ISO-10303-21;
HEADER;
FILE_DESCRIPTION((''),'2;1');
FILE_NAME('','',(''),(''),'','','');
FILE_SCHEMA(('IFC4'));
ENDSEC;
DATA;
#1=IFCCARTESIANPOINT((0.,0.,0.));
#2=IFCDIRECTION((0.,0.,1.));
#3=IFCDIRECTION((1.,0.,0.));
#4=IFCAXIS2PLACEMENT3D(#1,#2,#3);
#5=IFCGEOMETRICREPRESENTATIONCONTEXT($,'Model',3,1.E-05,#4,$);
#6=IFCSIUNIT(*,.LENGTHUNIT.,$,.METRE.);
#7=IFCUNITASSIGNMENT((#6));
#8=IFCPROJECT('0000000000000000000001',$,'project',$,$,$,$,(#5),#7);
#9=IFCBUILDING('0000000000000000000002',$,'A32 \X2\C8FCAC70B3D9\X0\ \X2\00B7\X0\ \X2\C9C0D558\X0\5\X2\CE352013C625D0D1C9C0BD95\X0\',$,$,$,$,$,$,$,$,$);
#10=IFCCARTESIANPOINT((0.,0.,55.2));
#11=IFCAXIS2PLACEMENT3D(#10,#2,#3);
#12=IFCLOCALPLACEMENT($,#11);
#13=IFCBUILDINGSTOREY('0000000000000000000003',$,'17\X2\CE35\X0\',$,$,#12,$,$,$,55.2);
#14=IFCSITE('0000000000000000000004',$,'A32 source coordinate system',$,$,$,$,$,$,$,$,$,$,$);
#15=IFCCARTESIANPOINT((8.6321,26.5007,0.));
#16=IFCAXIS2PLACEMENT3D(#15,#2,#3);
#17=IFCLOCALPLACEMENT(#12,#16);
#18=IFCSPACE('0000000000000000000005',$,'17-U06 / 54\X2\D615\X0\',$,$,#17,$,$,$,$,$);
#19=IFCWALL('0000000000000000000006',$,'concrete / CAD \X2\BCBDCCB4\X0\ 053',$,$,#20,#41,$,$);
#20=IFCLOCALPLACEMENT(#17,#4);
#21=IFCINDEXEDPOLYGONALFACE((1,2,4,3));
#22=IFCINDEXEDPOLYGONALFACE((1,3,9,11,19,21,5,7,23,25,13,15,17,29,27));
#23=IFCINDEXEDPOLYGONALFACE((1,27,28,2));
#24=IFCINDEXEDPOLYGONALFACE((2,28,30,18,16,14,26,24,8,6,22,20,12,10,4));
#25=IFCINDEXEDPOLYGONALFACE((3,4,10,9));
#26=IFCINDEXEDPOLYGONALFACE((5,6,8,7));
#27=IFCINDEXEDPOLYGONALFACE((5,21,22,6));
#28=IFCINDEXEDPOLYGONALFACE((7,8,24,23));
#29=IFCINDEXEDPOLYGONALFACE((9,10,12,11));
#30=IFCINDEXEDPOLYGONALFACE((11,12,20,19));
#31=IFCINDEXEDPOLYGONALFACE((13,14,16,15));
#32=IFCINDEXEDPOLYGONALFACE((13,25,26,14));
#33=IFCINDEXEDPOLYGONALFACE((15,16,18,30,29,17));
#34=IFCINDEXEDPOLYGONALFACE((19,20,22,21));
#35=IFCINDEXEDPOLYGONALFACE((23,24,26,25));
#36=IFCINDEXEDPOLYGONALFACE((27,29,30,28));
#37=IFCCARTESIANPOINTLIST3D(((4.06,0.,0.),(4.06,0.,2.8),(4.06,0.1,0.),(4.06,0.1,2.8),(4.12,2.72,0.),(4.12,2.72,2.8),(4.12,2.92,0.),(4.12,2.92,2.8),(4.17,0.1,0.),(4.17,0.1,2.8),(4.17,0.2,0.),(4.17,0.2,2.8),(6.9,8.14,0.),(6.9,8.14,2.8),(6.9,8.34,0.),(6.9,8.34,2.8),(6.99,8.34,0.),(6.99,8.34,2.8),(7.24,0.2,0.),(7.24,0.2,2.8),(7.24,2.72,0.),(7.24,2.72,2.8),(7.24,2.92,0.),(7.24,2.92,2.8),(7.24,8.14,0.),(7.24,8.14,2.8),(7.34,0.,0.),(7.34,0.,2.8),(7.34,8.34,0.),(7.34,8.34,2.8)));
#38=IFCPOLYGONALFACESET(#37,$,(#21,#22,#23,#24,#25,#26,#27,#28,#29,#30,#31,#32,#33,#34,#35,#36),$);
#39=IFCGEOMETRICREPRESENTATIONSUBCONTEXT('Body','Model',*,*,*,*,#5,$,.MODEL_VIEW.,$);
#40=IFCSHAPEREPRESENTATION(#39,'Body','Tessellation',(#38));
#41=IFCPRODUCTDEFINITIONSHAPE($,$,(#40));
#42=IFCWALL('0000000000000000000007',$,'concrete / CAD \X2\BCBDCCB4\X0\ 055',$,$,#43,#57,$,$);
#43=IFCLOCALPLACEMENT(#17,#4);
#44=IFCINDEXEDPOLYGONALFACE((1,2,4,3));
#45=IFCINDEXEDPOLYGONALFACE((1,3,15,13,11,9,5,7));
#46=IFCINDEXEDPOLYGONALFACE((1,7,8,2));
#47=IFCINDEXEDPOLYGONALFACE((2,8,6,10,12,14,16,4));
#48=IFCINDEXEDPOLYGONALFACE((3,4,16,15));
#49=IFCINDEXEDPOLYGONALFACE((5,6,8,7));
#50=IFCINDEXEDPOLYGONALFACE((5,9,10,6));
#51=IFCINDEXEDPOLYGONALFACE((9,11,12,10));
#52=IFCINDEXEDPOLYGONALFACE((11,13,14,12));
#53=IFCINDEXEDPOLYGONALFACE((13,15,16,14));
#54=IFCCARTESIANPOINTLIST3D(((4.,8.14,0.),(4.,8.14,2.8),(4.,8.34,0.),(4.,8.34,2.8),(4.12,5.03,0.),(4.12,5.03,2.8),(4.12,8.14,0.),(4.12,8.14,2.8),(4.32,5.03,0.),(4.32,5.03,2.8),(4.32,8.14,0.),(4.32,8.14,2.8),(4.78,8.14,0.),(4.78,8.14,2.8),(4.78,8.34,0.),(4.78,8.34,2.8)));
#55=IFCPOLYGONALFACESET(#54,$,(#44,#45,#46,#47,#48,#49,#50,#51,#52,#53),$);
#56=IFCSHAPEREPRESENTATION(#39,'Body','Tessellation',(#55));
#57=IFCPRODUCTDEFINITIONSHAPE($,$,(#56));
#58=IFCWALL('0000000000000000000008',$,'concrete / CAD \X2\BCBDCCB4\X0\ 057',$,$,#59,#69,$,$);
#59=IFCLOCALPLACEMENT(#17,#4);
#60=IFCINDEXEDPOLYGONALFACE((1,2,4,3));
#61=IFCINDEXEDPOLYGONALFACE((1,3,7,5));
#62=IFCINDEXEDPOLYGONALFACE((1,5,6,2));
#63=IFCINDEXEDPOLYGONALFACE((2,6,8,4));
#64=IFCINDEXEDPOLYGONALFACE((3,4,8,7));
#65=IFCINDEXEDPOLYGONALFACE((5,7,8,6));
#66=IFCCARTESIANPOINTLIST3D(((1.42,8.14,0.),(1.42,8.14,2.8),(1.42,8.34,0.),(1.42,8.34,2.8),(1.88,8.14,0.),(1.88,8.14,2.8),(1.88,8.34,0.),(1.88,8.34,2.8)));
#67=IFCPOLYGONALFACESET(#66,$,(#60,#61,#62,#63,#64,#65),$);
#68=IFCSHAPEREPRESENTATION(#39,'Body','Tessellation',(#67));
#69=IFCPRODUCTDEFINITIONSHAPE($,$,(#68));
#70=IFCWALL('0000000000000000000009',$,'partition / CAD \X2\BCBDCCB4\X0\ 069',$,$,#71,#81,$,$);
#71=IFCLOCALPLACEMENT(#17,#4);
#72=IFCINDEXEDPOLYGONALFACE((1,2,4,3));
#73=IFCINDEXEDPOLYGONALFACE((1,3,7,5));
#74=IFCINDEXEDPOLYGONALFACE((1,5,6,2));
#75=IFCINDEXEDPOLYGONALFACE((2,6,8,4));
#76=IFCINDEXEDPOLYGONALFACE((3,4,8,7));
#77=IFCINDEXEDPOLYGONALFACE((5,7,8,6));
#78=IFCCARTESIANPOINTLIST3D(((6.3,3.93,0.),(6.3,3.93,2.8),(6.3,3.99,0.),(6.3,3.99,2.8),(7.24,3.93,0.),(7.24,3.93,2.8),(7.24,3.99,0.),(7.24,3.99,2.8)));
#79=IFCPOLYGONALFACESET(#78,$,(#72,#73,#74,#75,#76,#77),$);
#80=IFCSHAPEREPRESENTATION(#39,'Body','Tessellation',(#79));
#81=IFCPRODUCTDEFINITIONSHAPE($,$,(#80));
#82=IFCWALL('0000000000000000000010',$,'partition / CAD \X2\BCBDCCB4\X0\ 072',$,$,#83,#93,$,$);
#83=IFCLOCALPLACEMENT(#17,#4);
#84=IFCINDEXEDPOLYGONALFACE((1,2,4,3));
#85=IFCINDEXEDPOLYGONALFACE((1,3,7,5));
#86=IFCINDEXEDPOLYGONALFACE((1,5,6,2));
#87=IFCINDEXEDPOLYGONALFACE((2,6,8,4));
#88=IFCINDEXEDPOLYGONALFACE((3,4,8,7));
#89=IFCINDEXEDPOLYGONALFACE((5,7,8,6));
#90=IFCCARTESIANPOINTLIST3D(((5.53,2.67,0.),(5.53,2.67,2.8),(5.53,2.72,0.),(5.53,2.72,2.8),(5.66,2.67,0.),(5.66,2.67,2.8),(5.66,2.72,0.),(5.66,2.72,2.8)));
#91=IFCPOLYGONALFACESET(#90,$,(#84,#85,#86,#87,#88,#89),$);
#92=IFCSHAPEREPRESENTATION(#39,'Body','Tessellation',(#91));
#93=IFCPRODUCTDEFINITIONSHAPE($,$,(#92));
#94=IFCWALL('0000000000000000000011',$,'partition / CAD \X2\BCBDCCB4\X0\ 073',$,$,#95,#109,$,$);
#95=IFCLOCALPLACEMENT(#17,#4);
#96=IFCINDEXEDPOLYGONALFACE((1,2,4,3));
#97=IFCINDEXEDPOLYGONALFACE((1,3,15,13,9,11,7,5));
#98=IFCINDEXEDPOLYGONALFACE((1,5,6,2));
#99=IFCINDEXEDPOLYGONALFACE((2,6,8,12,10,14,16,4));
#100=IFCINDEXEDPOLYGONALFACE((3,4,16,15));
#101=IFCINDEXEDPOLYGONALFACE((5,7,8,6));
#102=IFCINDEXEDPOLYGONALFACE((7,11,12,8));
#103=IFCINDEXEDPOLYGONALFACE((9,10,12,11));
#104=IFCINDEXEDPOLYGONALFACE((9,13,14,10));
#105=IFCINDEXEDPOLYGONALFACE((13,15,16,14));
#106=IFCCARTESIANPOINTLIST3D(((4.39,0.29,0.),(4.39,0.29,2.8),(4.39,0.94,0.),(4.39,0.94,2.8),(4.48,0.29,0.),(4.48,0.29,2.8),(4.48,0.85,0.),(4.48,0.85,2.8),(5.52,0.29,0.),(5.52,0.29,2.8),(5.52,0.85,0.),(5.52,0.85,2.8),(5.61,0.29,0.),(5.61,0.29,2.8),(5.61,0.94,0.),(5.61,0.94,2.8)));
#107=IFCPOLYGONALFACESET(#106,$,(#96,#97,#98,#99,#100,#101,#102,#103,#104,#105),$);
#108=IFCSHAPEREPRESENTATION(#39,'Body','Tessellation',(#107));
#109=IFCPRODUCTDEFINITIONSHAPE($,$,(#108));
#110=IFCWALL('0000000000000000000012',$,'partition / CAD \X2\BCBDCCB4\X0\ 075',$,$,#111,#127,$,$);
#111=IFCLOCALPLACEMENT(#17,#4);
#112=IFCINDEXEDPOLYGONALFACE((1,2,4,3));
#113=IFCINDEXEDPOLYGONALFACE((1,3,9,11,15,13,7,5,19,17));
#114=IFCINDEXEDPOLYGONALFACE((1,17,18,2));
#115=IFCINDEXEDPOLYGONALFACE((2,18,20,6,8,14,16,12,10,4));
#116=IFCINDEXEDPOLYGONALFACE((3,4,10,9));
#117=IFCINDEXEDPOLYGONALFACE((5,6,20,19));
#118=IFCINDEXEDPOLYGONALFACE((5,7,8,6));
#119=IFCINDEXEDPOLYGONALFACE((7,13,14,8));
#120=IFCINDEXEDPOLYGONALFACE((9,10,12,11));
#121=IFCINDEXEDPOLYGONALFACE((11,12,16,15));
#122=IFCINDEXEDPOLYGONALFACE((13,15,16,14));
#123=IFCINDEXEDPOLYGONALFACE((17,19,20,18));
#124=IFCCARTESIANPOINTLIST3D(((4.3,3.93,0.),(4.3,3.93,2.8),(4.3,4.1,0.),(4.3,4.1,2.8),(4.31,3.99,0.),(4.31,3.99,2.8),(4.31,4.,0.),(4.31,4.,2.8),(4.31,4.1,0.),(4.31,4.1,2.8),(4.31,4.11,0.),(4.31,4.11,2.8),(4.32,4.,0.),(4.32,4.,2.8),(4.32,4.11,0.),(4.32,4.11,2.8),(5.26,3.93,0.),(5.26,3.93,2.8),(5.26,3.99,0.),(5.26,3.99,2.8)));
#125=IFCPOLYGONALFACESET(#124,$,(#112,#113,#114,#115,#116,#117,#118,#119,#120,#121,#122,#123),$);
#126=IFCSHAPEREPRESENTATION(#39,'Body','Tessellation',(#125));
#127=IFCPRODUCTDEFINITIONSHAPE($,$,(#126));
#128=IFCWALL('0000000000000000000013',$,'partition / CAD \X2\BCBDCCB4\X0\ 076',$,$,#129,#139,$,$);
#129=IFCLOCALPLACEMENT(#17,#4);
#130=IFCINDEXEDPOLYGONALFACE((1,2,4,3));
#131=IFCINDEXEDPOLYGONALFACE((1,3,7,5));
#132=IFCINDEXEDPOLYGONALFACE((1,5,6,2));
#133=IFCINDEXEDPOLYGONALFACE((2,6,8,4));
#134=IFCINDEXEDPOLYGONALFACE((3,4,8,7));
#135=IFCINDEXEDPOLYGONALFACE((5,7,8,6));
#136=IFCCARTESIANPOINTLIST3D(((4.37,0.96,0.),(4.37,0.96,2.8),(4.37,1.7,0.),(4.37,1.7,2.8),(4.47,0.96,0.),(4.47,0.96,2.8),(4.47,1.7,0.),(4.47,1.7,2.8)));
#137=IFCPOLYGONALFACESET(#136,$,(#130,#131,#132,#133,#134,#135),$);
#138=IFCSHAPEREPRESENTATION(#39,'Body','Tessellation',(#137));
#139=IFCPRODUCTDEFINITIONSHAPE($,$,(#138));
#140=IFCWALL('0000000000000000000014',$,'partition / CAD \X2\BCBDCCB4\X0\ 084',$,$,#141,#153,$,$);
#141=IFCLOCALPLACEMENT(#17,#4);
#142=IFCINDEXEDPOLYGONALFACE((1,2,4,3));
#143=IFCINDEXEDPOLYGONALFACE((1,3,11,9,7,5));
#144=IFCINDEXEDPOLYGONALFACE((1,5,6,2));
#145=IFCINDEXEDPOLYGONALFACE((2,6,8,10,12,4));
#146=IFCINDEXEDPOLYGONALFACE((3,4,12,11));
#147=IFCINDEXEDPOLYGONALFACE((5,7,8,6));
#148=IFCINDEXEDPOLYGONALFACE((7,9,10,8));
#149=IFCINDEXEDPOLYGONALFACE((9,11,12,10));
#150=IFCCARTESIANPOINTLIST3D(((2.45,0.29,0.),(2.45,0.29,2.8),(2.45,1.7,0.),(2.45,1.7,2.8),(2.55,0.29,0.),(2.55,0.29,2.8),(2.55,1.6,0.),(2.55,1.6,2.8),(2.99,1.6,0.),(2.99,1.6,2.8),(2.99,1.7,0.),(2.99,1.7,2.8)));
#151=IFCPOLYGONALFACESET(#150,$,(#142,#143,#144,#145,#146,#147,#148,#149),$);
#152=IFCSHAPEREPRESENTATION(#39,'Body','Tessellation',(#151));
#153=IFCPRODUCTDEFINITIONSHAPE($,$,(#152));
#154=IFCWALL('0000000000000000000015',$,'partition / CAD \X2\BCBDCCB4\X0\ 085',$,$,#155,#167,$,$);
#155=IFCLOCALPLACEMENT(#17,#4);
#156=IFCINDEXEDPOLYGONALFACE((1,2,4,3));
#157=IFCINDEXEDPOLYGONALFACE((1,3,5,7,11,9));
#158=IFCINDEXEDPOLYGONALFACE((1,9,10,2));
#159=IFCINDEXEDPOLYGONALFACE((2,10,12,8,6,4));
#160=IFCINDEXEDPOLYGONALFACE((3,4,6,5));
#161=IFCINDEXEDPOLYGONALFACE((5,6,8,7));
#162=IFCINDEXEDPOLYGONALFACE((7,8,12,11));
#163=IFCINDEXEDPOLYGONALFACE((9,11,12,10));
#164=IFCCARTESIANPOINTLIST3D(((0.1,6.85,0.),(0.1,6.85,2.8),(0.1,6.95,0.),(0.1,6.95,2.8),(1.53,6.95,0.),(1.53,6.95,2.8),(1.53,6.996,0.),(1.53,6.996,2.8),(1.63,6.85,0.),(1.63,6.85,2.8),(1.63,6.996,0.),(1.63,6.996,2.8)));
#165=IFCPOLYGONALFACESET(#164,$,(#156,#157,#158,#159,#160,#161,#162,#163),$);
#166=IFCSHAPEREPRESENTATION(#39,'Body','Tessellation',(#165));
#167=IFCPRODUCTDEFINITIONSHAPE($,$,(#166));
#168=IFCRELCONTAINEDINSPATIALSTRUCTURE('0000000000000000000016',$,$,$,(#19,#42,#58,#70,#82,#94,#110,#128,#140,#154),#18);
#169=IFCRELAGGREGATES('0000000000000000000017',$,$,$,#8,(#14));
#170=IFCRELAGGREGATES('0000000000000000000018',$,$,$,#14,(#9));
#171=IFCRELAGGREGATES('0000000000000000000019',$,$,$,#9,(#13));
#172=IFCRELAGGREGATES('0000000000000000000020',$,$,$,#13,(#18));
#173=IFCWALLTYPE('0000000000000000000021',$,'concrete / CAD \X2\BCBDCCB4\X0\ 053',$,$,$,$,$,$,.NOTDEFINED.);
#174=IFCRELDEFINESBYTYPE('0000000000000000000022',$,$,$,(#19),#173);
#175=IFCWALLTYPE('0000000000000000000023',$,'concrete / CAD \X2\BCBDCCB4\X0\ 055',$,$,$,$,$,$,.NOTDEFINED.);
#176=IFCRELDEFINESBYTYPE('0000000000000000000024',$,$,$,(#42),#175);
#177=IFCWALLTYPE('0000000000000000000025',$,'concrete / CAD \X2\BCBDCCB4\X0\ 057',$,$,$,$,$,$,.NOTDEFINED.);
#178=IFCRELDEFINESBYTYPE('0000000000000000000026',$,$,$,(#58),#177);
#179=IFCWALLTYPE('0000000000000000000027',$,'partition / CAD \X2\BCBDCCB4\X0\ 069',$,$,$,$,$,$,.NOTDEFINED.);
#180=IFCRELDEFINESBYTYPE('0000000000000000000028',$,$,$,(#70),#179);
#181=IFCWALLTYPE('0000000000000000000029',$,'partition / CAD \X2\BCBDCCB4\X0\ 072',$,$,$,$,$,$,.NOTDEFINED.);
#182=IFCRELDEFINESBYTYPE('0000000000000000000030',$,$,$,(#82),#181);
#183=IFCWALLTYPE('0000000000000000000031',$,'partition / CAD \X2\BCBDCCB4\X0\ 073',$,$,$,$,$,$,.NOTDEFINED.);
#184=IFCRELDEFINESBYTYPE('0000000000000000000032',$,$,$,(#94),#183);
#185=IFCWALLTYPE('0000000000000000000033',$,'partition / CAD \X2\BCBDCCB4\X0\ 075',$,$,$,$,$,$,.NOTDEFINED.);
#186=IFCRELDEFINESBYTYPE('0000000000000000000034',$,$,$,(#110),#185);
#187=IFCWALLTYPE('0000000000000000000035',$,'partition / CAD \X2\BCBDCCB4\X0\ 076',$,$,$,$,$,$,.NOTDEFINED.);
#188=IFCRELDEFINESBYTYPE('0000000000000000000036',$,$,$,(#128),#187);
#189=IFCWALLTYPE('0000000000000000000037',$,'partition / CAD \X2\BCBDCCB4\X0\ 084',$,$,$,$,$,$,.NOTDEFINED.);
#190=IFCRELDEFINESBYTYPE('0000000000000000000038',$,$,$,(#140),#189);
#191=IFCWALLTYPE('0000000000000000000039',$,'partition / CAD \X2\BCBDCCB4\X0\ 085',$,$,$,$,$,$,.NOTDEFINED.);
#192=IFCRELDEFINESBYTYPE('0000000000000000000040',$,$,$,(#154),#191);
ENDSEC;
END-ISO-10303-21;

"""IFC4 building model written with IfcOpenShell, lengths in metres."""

from ifc_helpers import new_model, si_unit, frame, origin, origin_with_axes, place, context, subcontext, project, spatial, polyline, outline, extrude, source, transform, mapped, type_object, type_shapes, element, save


model = new_model("IFC4")

# Units and contexts
model_context = context("Model", 3, precision=1e-05, world=origin_with_axes())
body_context = subcontext(model_context, "Body", "Model", "MODEL_VIEW")
ifc_project = project(units=[si_unit("LENGTHUNIT", "METRE")], contexts=[model_context])

# Site, building, storey, space
site = spatial("IfcSite", under=ifc_project, Name="A32 source coordinate system")
building = spatial("IfcBuilding", under=site, Name="A32 주거동 · 지하5층–옥탑지붕")
storey_placement = place(None, frame((0.0, 0.0, 55.2), z_axis=(0.0, 0.0, 1.0), x_axis=(1.0, 0.0, 0.0)))
storey = spatial("IfcBuildingStorey", under=building, at=storey_placement, Name="17층", Elevation=55.2)
space_placement = place(storey_placement, frame((8.6321, 26.5007, 0.0), z_axis=(0.0, 0.0, 1.0), x_axis=(1.0, 0.0, 0.0)))
space = spatial("IfcSpace", under=storey, at=space_placement, Name="17-U06 / 54형")

# Walls
wall_type_1 = type_object("IfcWallType", Name="concrete / CAD 벽체 053", PredefinedType="NOTDEFINED")
shared_shape_1 = source(origin(), body_context, "Body", "SweptSolid", [
    extrude(outline(polyline([(7.24, 8.14), (6.9, 8.14), (6.9, 8.34), (6.99, 8.34), (6.99, 8.34), (7.34, 8.34), (7.34, 8.34), (7.34, 0.0), (4.06, 0.0), (4.06, 0.1), (4.17, 0.1), (4.17, 0.2), (7.24, 0.2), (7.24, 2.72), (4.12, 2.72), (4.12, 2.92), (7.24, 2.92), (7.24, 8.14)])), origin(), (0.0, 0.0, 1.0), 2.8),
])
type_shapes(wall_type_1, [shared_shape_1])
wall_1_placement = place(space_placement, origin_with_axes())
element("IfcWall", 1, at=wall_1_placement, inside=space, type_object=wall_type_1, Name="concrete / CAD 벽체 053", context=body_context, shape_type="MappedRepresentation", body=[
    mapped(shared_shape_1, transform((0.0, 0.0, 0.0), scale=1.0)),
])
wall_type_2 = type_object("IfcWallType", Name="concrete / CAD 벽체 055", PredefinedType="NOTDEFINED")
shared_shape_2 = source(origin(), body_context, "Body", "SweptSolid", [
    extrude(outline(polyline([(4.32, 5.03), (4.12, 5.03), (4.12, 8.14), (4.0, 8.14), (4.0, 8.34), (4.78, 8.34), (4.78, 8.14), (4.32, 8.14), (4.32, 5.03)])), origin(), (0.0, 0.0, 1.0), 2.8),
])
type_shapes(wall_type_2, [shared_shape_2])
wall_2_placement = place(space_placement, origin_with_axes())
element("IfcWall", 2, at=wall_2_placement, inside=space, type_object=wall_type_2, Name="concrete / CAD 벽체 055", context=body_context, shape_type="MappedRepresentation", body=[
    mapped(shared_shape_2, transform((0.0, 0.0, 0.0), scale=1.0)),
])
wall_type_3 = type_object("IfcWallType", Name="concrete / CAD 벽체 057", PredefinedType="NOTDEFINED")
shared_shape_3 = source(origin(), body_context, "Body", "SweptSolid", [
    extrude(outline(polyline([(1.42, 8.14), (1.42, 8.34), (1.88, 8.34), (1.88, 8.14), (1.42, 8.14)])), origin(), (0.0, 0.0, 1.0), 2.8),
])
type_shapes(wall_type_3, [shared_shape_3])
wall_3_placement = place(space_placement, origin_with_axes())
element("IfcWall", 3, at=wall_3_placement, inside=space, type_object=wall_type_3, Name="concrete / CAD 벽체 057", context=body_context, shape_type="MappedRepresentation", body=[
    mapped(shared_shape_3, transform((0.0, 0.0, 0.0), scale=1.0)),
])
wall_type_4 = type_object("IfcWallType", Name="partition / CAD 벽체 069", PredefinedType="NOTDEFINED")
shared_shape_4 = source(origin(), body_context, "Body", "SweptSolid", [
    extrude(outline(polyline([(7.24, 3.93), (6.3, 3.93), (6.3, 3.99), (7.24, 3.99), (7.24, 3.93)])), origin(), (0.0, 0.0, 1.0), 2.8),
])
type_shapes(wall_type_4, [shared_shape_4])
wall_4_placement = place(space_placement, origin_with_axes())
element("IfcWall", 4, at=wall_4_placement, inside=space, type_object=wall_type_4, Name="partition / CAD 벽체 069", context=body_context, shape_type="MappedRepresentation", body=[
    mapped(shared_shape_4, transform((0.0, 0.0, 0.0), scale=1.0)),
])
wall_type_5 = type_object("IfcWallType", Name="partition / CAD 벽체 072", PredefinedType="NOTDEFINED")
shared_shape_5 = source(origin(), body_context, "Body", "SweptSolid", [
    extrude(outline(polyline([(5.66, 2.67), (5.53, 2.67), (5.53, 2.72), (5.66, 2.72), (5.66, 2.67)])), origin(), (0.0, 0.0, 1.0), 2.8),
])
type_shapes(wall_type_5, [shared_shape_5])
wall_5_placement = place(space_placement, origin_with_axes())
element("IfcWall", 5, at=wall_5_placement, inside=space, type_object=wall_type_5, Name="partition / CAD 벽체 072", context=body_context, shape_type="MappedRepresentation", body=[
    mapped(shared_shape_5, transform((0.0, 0.0, 0.0), scale=1.0)),
])
wall_type_6 = type_object("IfcWallType", Name="partition / CAD 벽체 073", PredefinedType="NOTDEFINED")
shared_shape_6 = source(origin(), body_context, "Body", "SweptSolid", [
    extrude(outline(polyline([(4.48, 0.29), (4.39, 0.29), (4.39, 0.94), (5.61, 0.94), (5.61, 0.29), (5.52, 0.29), (5.52, 0.85), (4.48, 0.85), (4.48, 0.29)])), origin(), (0.0, 0.0, 1.0), 2.8),
])
type_shapes(wall_type_6, [shared_shape_6])
wall_6_placement = place(space_placement, origin_with_axes())
element("IfcWall", 6, at=wall_6_placement, inside=space, type_object=wall_type_6, Name="partition / CAD 벽체 073", context=body_context, shape_type="MappedRepresentation", body=[
    mapped(shared_shape_6, transform((0.0, 0.0, 0.0), scale=1.0)),
])
wall_type_7 = type_object("IfcWallType", Name="partition / CAD 벽체 075", PredefinedType="NOTDEFINED")
shared_shape_7 = source(origin(), body_context, "Body", "SweptSolid", [
    extrude(outline(polyline([(4.32, 4.0), (4.31, 4.0), (4.31, 3.99), (5.26, 3.99), (5.26, 3.93), (4.3, 3.93), (4.3, 4.1), (4.31, 4.1), (4.31, 4.11), (4.32, 4.11), (4.32, 4.0)])), origin(), (0.0, 0.0, 1.0), 2.8),
])
type_shapes(wall_type_7, [shared_shape_7])
wall_7_placement = place(space_placement, origin_with_axes())
element("IfcWall", 7, at=wall_7_placement, inside=space, type_object=wall_type_7, Name="partition / CAD 벽체 075", context=body_context, shape_type="MappedRepresentation", body=[
    mapped(shared_shape_7, transform((0.0, 0.0, 0.0), scale=1.0)),
])
wall_type_8 = type_object("IfcWallType", Name="partition / CAD 벽체 076", PredefinedType="NOTDEFINED")
shared_shape_8 = source(origin(), body_context, "Body", "SweptSolid", [
    extrude(outline(polyline([(4.37, 1.7), (4.47, 1.7), (4.47, 0.96), (4.37, 0.96), (4.37, 1.7)])), origin(), (0.0, 0.0, 1.0), 2.8),
])
type_shapes(wall_type_8, [shared_shape_8])
wall_8_placement = place(space_placement, origin_with_axes())
element("IfcWall", 8, at=wall_8_placement, inside=space, type_object=wall_type_8, Name="partition / CAD 벽체 076", context=body_context, shape_type="MappedRepresentation", body=[
    mapped(shared_shape_8, transform((0.0, 0.0, 0.0), scale=1.0)),
])
wall_type_9 = type_object("IfcWallType", Name="partition / CAD 벽체 084", PredefinedType="NOTDEFINED")
shared_shape_9 = source(origin(), body_context, "Body", "SweptSolid", [
    extrude(outline(polyline([(2.99, 1.6), (2.55, 1.6), (2.55, 0.29), (2.45, 0.29), (2.45, 1.7), (2.99, 1.7), (2.99, 1.6)])), origin(), (0.0, 0.0, 1.0), 2.8),
])
type_shapes(wall_type_9, [shared_shape_9])
wall_9_placement = place(space_placement, origin_with_axes())
element("IfcWall", 9, at=wall_9_placement, inside=space, type_object=wall_type_9, Name="partition / CAD 벽체 084", context=body_context, shape_type="MappedRepresentation", body=[
    mapped(shared_shape_9, transform((0.0, 0.0, 0.0), scale=1.0)),
])
wall_type_10 = type_object("IfcWallType", Name="partition / CAD 벽체 085", PredefinedType="NOTDEFINED")
shared_shape_10 = source(origin(), body_context, "Body", "SweptSolid", [
    extrude(outline(polyline([(1.63, 6.85), (0.1, 6.85), (0.1, 6.95), (1.53, 6.95), (1.53, 6.996), (1.63, 6.996), (1.63, 6.85)])), origin(), (0.0, 0.0, 1.0), 2.8),
])
type_shapes(wall_type_10, [shared_shape_10])
wall_10_placement = place(space_placement, origin_with_axes())
element("IfcWall", 10, at=wall_10_placement, inside=space, type_object=wall_type_10, Name="partition / CAD 벽체 085", context=body_context, shape_type="MappedRepresentation", body=[
    mapped(shared_shape_10, transform((0.0, 0.0, 0.0), scale=1.0)),
])

save(model, "model.ifc")
